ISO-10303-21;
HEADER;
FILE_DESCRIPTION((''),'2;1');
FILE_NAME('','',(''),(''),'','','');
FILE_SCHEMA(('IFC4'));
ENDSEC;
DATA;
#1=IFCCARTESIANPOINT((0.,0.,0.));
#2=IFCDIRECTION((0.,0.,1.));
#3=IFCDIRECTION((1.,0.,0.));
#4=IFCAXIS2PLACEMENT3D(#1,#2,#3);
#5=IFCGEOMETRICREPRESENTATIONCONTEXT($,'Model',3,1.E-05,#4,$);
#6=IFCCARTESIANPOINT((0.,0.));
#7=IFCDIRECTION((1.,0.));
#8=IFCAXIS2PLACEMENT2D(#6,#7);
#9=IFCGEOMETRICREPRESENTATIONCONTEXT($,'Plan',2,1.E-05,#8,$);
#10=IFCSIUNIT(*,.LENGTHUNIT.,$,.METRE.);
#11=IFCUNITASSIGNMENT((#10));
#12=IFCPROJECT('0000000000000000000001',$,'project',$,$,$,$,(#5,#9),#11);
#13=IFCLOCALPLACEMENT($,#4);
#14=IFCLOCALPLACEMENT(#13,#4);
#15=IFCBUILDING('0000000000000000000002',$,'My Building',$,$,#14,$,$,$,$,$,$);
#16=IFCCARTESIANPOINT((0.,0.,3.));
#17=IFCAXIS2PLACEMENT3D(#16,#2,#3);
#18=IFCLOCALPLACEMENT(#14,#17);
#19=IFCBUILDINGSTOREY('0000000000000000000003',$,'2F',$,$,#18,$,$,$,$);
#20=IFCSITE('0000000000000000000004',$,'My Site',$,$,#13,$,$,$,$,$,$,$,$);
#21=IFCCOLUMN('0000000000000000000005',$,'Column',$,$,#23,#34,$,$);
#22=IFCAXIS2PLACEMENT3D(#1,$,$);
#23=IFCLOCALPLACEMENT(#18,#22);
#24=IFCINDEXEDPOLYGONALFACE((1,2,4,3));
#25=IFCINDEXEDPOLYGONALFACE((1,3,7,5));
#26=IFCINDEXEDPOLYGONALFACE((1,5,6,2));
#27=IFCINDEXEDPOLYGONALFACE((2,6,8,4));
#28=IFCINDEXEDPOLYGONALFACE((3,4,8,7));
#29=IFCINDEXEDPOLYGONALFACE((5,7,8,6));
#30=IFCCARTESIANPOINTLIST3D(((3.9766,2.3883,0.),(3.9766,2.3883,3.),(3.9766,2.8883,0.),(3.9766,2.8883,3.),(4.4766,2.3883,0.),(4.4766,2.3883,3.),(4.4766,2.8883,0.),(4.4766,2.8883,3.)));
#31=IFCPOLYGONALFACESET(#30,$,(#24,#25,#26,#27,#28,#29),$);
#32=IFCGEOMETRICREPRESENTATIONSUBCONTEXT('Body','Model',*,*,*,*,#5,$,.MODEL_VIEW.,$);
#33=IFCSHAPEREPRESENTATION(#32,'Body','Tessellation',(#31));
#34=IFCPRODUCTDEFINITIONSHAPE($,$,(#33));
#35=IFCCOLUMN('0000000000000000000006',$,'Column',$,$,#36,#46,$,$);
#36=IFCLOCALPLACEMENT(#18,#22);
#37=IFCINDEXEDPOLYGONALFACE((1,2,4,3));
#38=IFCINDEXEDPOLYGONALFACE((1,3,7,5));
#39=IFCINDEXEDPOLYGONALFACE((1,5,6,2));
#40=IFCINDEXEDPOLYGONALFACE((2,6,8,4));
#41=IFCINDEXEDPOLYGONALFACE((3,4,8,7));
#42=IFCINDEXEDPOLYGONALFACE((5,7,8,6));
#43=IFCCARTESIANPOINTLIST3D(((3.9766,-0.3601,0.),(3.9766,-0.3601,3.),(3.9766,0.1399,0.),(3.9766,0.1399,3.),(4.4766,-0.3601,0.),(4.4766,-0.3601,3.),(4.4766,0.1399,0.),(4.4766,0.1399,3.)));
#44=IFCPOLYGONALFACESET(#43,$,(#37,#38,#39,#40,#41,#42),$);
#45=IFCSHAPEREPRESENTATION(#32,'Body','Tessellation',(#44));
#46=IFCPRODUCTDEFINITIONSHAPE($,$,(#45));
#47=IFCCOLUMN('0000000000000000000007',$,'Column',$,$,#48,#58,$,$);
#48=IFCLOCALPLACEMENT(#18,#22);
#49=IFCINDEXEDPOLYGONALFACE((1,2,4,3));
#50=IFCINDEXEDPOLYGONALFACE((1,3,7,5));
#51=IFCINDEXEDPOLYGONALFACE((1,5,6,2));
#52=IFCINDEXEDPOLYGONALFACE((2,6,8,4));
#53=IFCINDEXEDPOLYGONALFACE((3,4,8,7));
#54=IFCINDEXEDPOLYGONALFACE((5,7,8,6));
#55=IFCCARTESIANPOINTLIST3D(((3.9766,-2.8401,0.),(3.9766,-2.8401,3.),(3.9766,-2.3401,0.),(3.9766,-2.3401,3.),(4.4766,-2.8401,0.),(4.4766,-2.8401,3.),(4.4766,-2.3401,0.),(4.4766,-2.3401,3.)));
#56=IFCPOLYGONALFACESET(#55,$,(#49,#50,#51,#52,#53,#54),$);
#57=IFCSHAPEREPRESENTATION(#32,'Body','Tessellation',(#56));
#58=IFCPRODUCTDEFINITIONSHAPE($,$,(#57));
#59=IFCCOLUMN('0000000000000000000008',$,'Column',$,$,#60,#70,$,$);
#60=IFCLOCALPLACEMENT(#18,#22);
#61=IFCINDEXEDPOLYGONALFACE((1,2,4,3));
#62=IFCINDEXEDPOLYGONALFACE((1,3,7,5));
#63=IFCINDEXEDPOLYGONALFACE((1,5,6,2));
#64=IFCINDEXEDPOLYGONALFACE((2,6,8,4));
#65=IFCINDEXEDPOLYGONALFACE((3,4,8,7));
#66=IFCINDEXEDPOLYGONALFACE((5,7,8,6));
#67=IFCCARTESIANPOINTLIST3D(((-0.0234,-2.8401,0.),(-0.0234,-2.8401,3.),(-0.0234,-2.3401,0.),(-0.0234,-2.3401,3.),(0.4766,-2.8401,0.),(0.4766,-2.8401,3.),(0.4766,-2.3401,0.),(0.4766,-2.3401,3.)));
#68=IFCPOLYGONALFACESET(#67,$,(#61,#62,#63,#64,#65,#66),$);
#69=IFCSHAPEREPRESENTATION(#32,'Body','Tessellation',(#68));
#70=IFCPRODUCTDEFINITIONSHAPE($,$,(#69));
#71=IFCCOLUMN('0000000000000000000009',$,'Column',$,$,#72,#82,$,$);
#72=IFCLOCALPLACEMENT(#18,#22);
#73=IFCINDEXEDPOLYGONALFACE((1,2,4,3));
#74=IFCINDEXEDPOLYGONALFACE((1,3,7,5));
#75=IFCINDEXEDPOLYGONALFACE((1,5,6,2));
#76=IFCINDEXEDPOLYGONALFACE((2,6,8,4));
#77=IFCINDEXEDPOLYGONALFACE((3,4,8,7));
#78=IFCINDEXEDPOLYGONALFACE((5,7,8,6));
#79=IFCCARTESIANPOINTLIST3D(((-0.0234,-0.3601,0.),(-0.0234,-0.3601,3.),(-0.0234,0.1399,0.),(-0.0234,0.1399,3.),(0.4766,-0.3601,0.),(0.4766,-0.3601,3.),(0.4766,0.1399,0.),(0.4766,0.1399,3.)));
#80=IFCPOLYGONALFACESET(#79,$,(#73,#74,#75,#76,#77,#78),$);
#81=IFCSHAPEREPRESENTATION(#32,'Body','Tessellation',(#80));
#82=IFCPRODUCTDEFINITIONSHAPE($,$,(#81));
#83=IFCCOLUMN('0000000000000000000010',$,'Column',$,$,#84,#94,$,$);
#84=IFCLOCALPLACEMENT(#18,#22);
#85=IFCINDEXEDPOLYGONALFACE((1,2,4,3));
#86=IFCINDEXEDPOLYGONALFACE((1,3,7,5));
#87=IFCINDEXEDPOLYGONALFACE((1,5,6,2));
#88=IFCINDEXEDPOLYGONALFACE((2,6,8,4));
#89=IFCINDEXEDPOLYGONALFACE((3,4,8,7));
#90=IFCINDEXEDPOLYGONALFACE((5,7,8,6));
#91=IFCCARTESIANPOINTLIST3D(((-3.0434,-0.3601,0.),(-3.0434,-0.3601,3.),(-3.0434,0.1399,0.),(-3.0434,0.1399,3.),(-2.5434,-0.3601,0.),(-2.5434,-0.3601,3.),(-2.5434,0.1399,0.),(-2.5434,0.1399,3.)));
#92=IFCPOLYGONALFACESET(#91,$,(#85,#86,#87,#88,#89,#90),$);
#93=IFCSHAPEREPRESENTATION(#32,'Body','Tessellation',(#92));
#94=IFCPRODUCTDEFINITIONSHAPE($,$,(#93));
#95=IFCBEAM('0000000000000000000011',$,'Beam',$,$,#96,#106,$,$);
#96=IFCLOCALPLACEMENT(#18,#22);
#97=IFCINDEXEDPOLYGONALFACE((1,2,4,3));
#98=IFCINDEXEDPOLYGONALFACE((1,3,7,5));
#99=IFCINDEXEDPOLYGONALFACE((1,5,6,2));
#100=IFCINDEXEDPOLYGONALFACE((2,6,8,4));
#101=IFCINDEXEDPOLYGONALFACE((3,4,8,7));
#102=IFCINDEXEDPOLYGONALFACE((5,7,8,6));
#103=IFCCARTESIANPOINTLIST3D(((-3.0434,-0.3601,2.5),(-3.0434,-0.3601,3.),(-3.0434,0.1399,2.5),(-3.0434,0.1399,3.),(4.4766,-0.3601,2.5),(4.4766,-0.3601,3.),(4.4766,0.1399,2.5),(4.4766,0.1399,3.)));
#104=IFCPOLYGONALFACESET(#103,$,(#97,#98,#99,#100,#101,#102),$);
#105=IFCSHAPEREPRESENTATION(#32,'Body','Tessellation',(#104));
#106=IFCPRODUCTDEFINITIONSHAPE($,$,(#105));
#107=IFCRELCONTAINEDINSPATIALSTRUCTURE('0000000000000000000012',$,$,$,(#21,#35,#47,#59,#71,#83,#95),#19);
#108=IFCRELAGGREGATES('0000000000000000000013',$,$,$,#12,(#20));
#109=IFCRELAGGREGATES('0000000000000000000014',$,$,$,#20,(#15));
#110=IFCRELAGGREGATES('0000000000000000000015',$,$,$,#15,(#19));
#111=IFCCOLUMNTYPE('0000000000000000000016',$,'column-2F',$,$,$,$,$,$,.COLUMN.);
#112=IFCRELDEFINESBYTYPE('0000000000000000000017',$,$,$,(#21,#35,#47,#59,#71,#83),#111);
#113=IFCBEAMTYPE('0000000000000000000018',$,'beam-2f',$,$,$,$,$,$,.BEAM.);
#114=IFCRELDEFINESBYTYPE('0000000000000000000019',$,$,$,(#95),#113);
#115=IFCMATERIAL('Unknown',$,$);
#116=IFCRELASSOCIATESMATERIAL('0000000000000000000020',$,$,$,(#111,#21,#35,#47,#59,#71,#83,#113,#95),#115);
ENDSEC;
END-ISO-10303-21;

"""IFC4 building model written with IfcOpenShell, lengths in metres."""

from ifc_helpers import new_model, si_unit, frame, origin_with_axes, origin_2d_with_axis, place, context, subcontext, project, spatial, rectangle, extrude, material, material_profile, profile_set, profile_usage, type_object, element, save


model = new_model("IFC4")

# Units and contexts
model_context = context("Model", 3, precision=1e-05, world=origin_with_axes())
plan_context = context("Plan", 2, precision=1e-05, world=origin_2d_with_axis())
body_context_1 = subcontext(model_context, "Body", "Model", "MODEL_VIEW")
ifc_project = project(units=[si_unit("LENGTHUNIT", "METRE")], contexts=[model_context, plan_context])

# Site, building, storey
site_placement = place(None, origin_with_axes())
site = spatial("IfcSite", under=ifc_project, at=site_placement, Name="My Site")
building_placement = place(site_placement, origin_with_axes())
building = spatial("IfcBuilding", under=site, at=building_placement, Name="My Building")
storey_placement = place(building_placement, frame((0.0, 0.0, 3.0), z_axis=(0.0, 0.0, 1.0), x_axis=(1.0, 0.0, 0.0)))
storey = spatial("IfcBuildingStorey", under=building, at=storey_placement, Name="2F")

# Columns
ifc_material = material(Name="Unknown")
ifc_material_profile_1 = material_profile(ifc_material, rectangle(XDim=0.5, YDim=0.5))
ifc_profile_set_1 = profile_set([ifc_material_profile_1])
ifc_profile_usage_1 = profile_usage(ifc_profile_set_1, cardinal=7)
column_type = type_object("IfcColumnType", Name="column-2F", PredefinedType="COLUMN", material=ifc_profile_set_1)
column_1_placement = place(storey_placement, frame((4.4766, 2.8883, 0.0), z_axis=(0.0, 0.0, 1.0), x_axis=(1.0, 0.0, 0.0)))
element("IfcColumn", 1, at=column_1_placement, inside=storey, type_object=column_type, material=ifc_profile_usage_1, Name="Column", context=body_context_1, shape_type="SweptSolid", body=[
    extrude(rectangle(XDim=0.5, YDim=0.5), frame((-0.25, -0.25, 0.0), z_axis=(0.0, 0.0, 1.0), x_axis=(1.0, 0.0, 0.0)), (0.0, 0.0, 1.0), 3.0),
])
ifc_profile_usage_2 = profile_usage(ifc_profile_set_1, cardinal=7)
column_2_placement = place(storey_placement, frame((4.4766, 0.1399, 0.0), z_axis=(0.0, 0.0, 1.0), x_axis=(1.0, 0.0, 0.0)))
element("IfcColumn", 2, at=column_2_placement, inside=storey, type_object=column_type, material=ifc_profile_usage_2, Name="Column", context=body_context_1, shape_type="SweptSolid", body=[
    extrude(rectangle(XDim=0.5, YDim=0.5), frame((-0.25, -0.25, 0.0), z_axis=(0.0, 0.0, 1.0), x_axis=(1.0, 0.0, 0.0)), (0.0, 0.0, 1.0), 3.0),
])
ifc_profile_usage_3 = profile_usage(ifc_profile_set_1, cardinal=7)
column_3_placement = place(storey_placement, frame((4.4766, -2.3401, 0.0), z_axis=(0.0, 0.0, 1.0), x_axis=(1.0, 0.0, 0.0)))
element("IfcColumn", 3, at=column_3_placement, inside=storey, type_object=column_type, material=ifc_profile_usage_3, Name="Column", context=body_context_1, shape_type="SweptSolid", body=[
    extrude(rectangle(XDim=0.5, YDim=0.5), frame((-0.25, -0.25, 0.0), z_axis=(0.0, 0.0, 1.0), x_axis=(1.0, 0.0, 0.0)), (0.0, 0.0, 1.0), 3.0),
])
ifc_profile_usage_4 = profile_usage(ifc_profile_set_1, cardinal=7)
column_4_placement = place(storey_placement, frame((0.4766, -2.3401, 0.0), z_axis=(0.0, 0.0, 1.0), x_axis=(1.0, 0.0, 0.0)))
element("IfcColumn", 4, at=column_4_placement, inside=storey, type_object=column_type, material=ifc_profile_usage_4, Name="Column", context=body_context_1, shape_type="SweptSolid", body=[
    extrude(rectangle(XDim=0.5, YDim=0.5), frame((-0.25, -0.25, 0.0), z_axis=(0.0, 0.0, 1.0), x_axis=(1.0, 0.0, 0.0)), (0.0, 0.0, 1.0), 3.0),
])
ifc_profile_usage_5 = profile_usage(ifc_profile_set_1, cardinal=7)
column_5_placement = place(storey_placement, frame((0.4766, 0.1399, 0.0), z_axis=(0.0, 0.0, 1.0), x_axis=(1.0, 0.0, 0.0)))
element("IfcColumn", 5, at=column_5_placement, inside=storey, type_object=column_type, material=ifc_profile_usage_5, Name="Column", context=body_context_1, shape_type="SweptSolid", body=[
    extrude(rectangle(XDim=0.5, YDim=0.5), frame((-0.25, -0.25, 0.0), z_axis=(0.0, 0.0, 1.0), x_axis=(1.0, 0.0, 0.0)), (0.0, 0.0, 1.0), 3.0),
])
ifc_profile_usage_6 = profile_usage(ifc_profile_set_1, cardinal=7)
column_6_placement = place(storey_placement, frame((-2.5434, 0.1399, 0.0), z_axis=(0.0, 0.0, 1.0), x_axis=(1.0, 0.0, 0.0)))
element("IfcColumn", 6, at=column_6_placement, inside=storey, type_object=column_type, material=ifc_profile_usage_6, Name="Column", context=body_context_1, shape_type="SweptSolid", body=[
    extrude(rectangle(XDim=0.5, YDim=0.5), frame((-0.25, -0.25, 0.0), z_axis=(0.0, 0.0, 1.0), x_axis=(1.0, 0.0, 0.0)), (0.0, 0.0, 1.0), 3.0),
])

# Beam
ifc_material_profile_2 = material_profile(ifc_material, rectangle(XDim=0.5, YDim=0.5))
ifc_profile_set_2 = profile_set([ifc_material_profile_2])
ifc_profile_usage_7 = profile_usage(ifc_profile_set_2, cardinal=7)
beam_type = type_object("IfcBeamType", Name="beam-2f", PredefinedType="BEAM", material=ifc_profile_set_2)
beam_placement = place(storey_placement, frame((-3.0434, 0.1399, 3.0), z_axis=(1.0, -0.000001, 0.000001), x_axis=(0.000001, 1.0, 0.0)))
element("IfcBeam", 7, at=beam_placement, inside=storey, type_object=beam_type, material=ifc_profile_usage_7, Name="Beam", context=body_context_1, shape_type="SweptSolid", body=[
    extrude(rectangle(XDim=0.5, YDim=0.5), frame((-0.25, -0.25, 0.0), z_axis=(0.0, 0.0, 1.0), x_axis=(1.0, 0.0, 0.0)), (0.0, 0.0, 1.0), 7.52),
])

save(model, "model.ifc")
